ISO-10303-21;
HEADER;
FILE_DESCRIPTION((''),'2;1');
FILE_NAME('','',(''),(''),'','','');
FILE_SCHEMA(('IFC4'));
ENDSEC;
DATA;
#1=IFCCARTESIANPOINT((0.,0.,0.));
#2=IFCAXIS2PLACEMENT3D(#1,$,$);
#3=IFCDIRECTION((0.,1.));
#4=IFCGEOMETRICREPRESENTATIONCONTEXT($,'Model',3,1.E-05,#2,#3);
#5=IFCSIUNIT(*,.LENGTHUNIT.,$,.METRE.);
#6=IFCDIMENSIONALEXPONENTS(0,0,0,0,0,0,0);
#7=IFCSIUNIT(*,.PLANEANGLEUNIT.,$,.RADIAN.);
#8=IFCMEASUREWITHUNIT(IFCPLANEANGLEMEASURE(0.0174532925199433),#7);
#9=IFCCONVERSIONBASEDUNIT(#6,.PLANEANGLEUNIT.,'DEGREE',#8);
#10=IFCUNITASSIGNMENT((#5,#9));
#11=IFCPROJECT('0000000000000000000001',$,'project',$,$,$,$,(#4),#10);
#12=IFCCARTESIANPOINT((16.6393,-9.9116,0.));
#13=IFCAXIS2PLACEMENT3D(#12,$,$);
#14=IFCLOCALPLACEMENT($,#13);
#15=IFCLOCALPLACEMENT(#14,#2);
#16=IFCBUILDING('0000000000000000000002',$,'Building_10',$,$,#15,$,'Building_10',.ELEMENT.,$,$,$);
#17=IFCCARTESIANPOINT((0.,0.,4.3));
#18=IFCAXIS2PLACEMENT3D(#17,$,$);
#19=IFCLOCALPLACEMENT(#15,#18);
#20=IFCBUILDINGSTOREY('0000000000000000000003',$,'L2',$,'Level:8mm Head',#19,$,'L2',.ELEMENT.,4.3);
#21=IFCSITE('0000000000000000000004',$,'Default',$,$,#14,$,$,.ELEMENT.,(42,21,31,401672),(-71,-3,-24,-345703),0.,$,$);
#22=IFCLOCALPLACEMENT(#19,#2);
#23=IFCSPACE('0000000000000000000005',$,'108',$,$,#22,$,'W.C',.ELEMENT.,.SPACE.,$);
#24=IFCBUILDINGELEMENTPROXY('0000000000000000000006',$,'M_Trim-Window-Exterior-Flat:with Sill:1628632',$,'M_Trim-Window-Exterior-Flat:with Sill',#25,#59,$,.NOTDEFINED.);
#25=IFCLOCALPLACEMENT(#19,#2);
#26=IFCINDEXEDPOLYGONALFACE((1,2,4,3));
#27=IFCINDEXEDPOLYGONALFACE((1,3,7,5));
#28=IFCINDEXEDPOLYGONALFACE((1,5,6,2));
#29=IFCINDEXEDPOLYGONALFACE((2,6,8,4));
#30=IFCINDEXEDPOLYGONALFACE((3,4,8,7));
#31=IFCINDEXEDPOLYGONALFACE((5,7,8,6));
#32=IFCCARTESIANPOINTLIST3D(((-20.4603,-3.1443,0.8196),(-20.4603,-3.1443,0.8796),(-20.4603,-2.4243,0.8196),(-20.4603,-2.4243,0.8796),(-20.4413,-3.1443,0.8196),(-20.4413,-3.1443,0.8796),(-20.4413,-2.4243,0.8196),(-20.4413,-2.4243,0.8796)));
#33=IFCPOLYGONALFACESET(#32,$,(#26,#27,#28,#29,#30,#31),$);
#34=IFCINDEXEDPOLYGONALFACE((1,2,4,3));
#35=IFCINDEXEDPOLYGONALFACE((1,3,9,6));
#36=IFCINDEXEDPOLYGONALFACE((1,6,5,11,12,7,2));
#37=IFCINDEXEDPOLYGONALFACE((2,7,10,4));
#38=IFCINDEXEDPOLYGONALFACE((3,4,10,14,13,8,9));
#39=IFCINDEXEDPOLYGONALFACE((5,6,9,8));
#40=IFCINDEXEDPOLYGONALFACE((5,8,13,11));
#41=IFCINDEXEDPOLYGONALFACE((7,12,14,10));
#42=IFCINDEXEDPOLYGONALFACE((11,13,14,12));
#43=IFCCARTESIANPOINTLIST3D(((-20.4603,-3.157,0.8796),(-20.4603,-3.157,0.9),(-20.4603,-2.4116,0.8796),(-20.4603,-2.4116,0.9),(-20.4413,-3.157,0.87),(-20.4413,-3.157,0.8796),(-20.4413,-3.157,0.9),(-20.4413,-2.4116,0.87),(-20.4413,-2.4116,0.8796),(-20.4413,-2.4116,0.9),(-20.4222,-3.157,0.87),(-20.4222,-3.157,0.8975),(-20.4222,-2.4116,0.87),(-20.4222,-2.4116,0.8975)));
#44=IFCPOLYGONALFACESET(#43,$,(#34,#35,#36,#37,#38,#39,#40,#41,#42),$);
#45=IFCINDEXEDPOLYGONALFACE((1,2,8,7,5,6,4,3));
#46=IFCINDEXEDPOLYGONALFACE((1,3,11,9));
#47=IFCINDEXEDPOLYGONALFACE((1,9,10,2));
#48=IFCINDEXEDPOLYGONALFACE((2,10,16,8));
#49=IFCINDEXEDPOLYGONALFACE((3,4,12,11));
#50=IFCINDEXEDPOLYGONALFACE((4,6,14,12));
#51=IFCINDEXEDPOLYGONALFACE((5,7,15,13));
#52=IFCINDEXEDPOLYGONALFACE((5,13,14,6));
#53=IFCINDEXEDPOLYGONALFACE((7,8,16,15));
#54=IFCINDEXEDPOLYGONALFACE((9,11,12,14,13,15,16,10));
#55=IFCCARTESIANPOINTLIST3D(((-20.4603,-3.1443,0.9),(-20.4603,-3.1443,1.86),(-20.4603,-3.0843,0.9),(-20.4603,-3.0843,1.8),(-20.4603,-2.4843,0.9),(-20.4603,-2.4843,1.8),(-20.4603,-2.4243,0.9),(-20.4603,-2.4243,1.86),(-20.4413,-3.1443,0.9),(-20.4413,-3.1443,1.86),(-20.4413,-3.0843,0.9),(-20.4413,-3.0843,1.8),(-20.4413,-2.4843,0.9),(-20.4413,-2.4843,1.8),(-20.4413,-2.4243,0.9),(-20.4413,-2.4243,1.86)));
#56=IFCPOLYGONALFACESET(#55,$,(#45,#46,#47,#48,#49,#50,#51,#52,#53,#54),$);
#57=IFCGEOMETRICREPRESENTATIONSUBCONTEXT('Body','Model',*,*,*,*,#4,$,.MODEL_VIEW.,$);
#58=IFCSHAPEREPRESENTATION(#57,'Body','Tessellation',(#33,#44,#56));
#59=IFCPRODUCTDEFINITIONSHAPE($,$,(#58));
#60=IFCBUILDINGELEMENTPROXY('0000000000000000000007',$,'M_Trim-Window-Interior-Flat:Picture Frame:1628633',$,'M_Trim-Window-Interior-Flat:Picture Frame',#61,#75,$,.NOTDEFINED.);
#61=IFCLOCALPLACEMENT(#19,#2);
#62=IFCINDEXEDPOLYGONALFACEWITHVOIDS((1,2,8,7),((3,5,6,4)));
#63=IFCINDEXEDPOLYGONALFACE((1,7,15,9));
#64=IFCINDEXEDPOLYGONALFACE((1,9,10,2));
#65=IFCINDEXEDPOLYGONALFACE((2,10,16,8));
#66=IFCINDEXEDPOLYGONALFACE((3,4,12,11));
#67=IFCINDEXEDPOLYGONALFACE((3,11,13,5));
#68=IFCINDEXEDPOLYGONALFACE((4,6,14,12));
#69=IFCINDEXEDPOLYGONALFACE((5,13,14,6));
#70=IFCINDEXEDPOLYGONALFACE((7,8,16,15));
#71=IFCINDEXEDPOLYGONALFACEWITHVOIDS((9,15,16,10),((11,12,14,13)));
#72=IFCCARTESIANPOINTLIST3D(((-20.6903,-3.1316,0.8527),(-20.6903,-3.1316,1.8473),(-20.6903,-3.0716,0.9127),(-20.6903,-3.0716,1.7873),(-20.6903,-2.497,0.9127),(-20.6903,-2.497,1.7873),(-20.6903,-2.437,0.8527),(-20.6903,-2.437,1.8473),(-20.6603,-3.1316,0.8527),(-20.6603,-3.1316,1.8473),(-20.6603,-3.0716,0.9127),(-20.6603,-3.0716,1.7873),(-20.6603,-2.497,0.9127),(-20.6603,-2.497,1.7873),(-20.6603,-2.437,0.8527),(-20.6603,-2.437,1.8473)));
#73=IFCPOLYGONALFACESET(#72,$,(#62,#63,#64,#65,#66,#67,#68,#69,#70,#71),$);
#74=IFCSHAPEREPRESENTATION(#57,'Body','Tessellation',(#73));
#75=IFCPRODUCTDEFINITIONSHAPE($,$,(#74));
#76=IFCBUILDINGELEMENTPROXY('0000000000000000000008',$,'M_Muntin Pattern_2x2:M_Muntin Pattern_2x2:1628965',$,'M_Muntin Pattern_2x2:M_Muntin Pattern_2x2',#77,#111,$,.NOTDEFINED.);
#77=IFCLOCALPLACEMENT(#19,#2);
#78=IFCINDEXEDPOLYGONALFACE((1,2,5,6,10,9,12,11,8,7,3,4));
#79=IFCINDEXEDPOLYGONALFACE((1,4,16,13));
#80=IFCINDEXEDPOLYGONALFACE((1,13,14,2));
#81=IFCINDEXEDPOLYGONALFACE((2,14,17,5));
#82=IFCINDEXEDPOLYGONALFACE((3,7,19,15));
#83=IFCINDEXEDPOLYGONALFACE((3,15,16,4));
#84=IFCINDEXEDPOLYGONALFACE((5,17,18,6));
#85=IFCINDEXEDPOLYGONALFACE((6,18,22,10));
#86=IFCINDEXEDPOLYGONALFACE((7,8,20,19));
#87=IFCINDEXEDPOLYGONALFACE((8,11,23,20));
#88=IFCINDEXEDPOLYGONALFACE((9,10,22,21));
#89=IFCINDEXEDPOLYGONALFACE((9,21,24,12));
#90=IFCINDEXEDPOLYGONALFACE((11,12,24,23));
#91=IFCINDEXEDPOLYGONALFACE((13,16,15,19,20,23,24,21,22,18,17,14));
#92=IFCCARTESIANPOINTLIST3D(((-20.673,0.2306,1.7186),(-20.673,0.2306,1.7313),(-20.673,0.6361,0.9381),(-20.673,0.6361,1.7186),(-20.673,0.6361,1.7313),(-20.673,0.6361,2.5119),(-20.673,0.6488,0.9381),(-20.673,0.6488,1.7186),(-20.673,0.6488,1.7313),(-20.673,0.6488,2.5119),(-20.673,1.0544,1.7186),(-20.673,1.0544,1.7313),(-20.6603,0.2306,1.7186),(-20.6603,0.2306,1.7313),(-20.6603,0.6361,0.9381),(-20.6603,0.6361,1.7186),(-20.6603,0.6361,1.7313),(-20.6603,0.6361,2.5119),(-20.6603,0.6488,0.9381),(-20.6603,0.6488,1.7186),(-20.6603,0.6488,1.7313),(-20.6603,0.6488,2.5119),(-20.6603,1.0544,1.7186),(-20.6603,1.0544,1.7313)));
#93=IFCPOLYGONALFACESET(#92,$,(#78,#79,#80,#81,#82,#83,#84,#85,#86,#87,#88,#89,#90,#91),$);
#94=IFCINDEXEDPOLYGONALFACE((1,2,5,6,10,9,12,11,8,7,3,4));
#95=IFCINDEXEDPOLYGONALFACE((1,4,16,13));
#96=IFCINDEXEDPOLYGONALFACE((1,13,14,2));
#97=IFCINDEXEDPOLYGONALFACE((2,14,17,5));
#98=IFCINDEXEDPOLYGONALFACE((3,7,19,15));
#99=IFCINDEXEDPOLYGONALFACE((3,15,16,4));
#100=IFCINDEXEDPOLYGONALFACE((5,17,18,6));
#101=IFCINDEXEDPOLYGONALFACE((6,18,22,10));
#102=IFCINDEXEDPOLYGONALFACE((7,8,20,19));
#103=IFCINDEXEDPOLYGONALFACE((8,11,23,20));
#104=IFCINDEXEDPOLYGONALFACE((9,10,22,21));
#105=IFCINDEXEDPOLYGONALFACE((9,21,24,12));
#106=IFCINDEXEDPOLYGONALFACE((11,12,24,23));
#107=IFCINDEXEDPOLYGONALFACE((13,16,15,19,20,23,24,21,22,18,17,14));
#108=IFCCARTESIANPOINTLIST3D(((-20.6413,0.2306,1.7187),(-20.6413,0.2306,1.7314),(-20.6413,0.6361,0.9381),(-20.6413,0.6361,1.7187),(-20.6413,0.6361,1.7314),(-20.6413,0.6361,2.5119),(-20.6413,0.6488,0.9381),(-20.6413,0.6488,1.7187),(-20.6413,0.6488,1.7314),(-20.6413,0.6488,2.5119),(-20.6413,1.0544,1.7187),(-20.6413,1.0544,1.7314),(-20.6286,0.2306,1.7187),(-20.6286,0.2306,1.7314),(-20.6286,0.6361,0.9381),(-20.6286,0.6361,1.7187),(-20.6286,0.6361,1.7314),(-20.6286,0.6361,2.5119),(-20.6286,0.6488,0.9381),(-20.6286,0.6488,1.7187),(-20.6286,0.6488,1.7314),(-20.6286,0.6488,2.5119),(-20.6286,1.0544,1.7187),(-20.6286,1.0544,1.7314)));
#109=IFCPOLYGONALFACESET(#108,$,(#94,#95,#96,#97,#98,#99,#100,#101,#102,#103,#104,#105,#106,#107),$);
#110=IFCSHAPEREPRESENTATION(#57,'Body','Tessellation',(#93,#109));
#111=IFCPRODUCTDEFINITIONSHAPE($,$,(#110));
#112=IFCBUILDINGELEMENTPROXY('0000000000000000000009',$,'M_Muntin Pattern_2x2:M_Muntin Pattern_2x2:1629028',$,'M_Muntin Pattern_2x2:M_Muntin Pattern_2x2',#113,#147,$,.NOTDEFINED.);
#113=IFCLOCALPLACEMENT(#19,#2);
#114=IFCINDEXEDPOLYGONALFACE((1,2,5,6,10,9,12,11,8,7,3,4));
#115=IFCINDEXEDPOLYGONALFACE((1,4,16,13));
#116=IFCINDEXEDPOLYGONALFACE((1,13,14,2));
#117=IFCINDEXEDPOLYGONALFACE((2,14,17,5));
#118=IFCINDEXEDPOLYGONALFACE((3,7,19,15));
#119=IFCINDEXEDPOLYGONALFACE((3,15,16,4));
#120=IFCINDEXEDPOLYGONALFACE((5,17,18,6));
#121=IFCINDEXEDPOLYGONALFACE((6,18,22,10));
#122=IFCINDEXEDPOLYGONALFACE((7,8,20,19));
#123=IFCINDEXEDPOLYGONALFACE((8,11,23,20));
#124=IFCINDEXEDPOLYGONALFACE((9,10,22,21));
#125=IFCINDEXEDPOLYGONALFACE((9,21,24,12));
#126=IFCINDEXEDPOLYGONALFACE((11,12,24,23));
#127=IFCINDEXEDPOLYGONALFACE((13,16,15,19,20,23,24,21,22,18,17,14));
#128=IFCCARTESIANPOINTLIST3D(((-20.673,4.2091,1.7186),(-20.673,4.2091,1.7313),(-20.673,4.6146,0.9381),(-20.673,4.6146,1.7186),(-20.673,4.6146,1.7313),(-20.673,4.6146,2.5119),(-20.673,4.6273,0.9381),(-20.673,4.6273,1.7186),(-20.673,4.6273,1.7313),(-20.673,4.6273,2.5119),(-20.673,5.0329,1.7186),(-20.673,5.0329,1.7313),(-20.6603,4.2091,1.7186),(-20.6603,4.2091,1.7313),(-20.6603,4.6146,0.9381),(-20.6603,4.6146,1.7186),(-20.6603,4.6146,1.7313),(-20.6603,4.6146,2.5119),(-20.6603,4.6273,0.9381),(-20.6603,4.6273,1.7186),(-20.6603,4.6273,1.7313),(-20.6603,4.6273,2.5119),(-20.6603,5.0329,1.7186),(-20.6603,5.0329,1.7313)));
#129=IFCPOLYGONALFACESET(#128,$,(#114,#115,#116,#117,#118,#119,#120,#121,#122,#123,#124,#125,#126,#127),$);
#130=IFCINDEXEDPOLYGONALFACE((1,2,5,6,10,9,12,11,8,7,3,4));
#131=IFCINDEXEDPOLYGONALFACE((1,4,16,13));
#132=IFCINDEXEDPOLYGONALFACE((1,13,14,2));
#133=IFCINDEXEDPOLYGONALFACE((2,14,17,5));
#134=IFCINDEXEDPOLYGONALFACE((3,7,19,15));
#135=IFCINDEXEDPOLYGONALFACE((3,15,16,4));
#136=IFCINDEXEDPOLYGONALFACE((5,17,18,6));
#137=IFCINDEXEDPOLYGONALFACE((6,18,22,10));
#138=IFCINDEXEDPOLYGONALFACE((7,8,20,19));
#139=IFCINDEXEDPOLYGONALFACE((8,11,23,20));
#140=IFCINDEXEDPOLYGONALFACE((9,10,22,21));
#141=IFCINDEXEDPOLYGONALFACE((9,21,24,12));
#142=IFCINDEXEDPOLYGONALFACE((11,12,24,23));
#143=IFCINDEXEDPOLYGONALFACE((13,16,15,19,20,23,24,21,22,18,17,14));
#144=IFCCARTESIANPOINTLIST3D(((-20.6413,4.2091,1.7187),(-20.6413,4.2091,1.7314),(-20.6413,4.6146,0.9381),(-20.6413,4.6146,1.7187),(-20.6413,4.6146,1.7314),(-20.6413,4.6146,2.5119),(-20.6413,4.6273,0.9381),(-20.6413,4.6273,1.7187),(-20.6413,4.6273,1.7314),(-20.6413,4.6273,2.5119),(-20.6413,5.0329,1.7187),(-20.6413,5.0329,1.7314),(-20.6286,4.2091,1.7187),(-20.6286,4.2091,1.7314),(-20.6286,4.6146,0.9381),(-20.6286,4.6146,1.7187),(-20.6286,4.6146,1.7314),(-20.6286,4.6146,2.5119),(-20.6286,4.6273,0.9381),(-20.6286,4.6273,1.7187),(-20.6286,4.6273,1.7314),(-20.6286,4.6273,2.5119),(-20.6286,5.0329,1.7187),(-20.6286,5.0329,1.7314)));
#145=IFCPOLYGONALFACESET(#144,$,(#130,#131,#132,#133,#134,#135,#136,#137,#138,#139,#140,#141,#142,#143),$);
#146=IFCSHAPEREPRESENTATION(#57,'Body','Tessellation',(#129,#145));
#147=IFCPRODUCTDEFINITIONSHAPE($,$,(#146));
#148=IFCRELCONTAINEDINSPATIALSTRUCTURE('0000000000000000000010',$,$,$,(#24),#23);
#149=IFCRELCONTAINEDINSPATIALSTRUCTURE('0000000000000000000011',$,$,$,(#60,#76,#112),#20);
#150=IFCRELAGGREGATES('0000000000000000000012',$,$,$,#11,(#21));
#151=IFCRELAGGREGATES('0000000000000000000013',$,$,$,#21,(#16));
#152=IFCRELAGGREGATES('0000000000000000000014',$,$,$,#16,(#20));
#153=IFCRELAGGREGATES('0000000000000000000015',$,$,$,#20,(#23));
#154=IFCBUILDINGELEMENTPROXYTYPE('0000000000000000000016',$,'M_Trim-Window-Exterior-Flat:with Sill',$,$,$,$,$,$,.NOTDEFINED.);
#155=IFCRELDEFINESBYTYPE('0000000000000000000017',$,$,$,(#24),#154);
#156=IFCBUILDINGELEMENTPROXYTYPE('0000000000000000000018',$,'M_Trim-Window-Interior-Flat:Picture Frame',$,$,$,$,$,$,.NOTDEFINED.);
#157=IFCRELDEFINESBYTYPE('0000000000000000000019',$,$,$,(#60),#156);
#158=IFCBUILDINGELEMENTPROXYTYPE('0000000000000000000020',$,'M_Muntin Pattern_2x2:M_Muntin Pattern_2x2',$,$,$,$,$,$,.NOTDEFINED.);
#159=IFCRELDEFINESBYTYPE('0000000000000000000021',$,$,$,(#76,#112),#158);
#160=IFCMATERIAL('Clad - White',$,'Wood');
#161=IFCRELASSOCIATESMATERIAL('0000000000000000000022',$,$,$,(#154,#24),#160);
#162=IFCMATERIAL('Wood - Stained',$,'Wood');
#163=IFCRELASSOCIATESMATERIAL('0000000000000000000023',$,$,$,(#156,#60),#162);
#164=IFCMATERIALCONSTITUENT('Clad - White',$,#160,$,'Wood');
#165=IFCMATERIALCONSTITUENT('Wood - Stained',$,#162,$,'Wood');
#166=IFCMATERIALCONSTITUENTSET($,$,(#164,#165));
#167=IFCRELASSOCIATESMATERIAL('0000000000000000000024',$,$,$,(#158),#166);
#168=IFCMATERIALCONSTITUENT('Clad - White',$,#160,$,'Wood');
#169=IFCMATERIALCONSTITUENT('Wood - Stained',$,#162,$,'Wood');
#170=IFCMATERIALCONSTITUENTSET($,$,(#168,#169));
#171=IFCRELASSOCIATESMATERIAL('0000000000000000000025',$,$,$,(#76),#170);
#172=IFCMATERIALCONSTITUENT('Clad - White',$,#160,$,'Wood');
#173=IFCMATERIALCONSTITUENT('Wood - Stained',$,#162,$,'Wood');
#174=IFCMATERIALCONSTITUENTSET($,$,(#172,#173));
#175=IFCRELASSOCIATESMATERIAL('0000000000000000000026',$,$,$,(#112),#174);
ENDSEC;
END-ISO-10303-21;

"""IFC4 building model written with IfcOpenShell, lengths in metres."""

from ifc_helpers import new_model, entity, si_unit, converted_unit, direction, frame, origin, place, context, subcontext, project, spatial, indexed_curve, outline, extrude, source, transform, mapped, material, constituent, constituent_set, type_object, type_shapes, element, save


model = new_model("IFC4")

# Units and contexts
model_context = context("Model", 3, precision=1e-05, world=origin(), true_north=direction((0.0, 1.0)))
body_context = subcontext(model_context, "Body", "Model", "MODEL_VIEW")
ifc_project = project(units=[si_unit("LENGTHUNIT", "METRE"), converted_unit("PLANEANGLEUNIT", "DEGREE", entity("IfcPlaneAngleMeasure", 0.0174532925199433), si_unit("PLANEANGLEUNIT", "RADIAN"), dimensions=[0, 0, 0, 0, 0, 0, 0])], contexts=[model_context])

# Site, building, storey
site_placement = place(None, frame((16.6393, -9.9116, 0.0)))
site = spatial("IfcSite", under=ifc_project, at=site_placement, Name="Default", CompositionType="ELEMENT", RefLatitude=(42, 21, 31, 401672), RefLongitude=(-71, -3, -24, -345703), RefElevation=0.0)
building_placement = place(site_placement, origin())
building = spatial("IfcBuilding", under=site, at=building_placement, Name="Building_10", LongName="Building_10", CompositionType="ELEMENT")
storey_placement = place(building_placement, frame((0.0, 0.0, 4.3)))
storey = spatial("IfcBuildingStorey", under=building, at=storey_placement, Name="L2", ObjectType="Level:8mm Head", LongName="L2", CompositionType="ELEMENT", Elevation=4.3)

# Shared definitions
ifc_material_1 = material(Name="Clad - White", Category="Wood")
ifc_material_2 = material(Name="Wood - Stained", Category="Wood")

# Shared definitions
space_1_placement = place(storey_placement, origin())
space_1 = spatial("IfcSpace", under=storey, at=space_1_placement, Name="108", LongName="W.C", CompositionType="ELEMENT", PredefinedType="SPACE")

# Building element proxies
building_element_proxy_type_1 = type_object("IfcBuildingElementProxyType", Name="M_Trim-Window-Exterior-Flat:with Sill", PredefinedType="NOTDEFINED", material=ifc_material_1)
shared_shape_1 = source(origin(), body_context, "Body", "SweptSolid", [
    extrude(outline(indexed_curve([(-0.36, -0.03), (0.36, -0.03), (0.36, 0.03), (-0.36, 0.03), (-0.36, -0.03)], self_intersect=False)), frame((0.0, -0.9504, 0.0), z_axis=(0.0, 0.0, 1.0), x_axis=(-1.0, 0.0, 0.0)), (0.0, 0.0, 1.0), 0.0191),
    extrude(outline(indexed_curve([(-0.019, -0.0152), (0.0, -0.0152), (0.0, -0.0057), (0.019, -0.0057), (0.019, 0.0148), (0.0, 0.0148), (-0.019, 0.0123), (-0.019, -0.0152)], self_intersect=False)), frame((-0.3727, -0.9148, 0.019), z_axis=(1.0, 0.0, 0.0), x_axis=(0.0, 0.0, -1.0)), (0.0, 0.0, 1.0), 0.7454),
    extrude(outline(indexed_curve([(-0.495, -0.36), (0.465, -0.36), (0.465, -0.3), (-0.435, -0.3), (-0.435, 0.3), (0.465, 0.3), (0.465, 0.36), (-0.495, 0.36), (-0.495, -0.36)], self_intersect=False)), frame((0.0, -0.435, 0.0), z_axis=(0.0, 0.0, 1.0), x_axis=(0.0, -1.0, 0.0)), (0.0, 0.0, 1.0), 0.0191),
])
type_shapes(building_element_proxy_type_1, [shared_shape_1])
proxy_1_placement = place(space_1_placement, frame((-20.4603, -2.7843, 1.8), z_axis=(1.0, 0.0, 0.0), x_axis=(0.0, 1.0, 0.0)))
element("IfcBuildingElementProxy", 1, at=proxy_1_placement, inside=space_1, type_object=building_element_proxy_type_1, material=ifc_material_1, Name="M_Trim-Window-Exterior-Flat:with Sill:1628632", ObjectType="M_Trim-Window-Exterior-Flat:with Sill", PredefinedType="NOTDEFINED", context=body_context, shape_type="MappedRepresentation", body=[
    mapped(shared_shape_1, transform((0.0, 0.0, 0.0), scale=1.0)),
])
building_element_proxy_type_2 = type_object("IfcBuildingElementProxyType", Name="M_Trim-Window-Interior-Flat:Picture Frame", PredefinedType="NOTDEFINED", material=ifc_material_2)
shared_shape_2 = source(origin(), body_context, "Body", "SweptSolid", [
    extrude(outline(indexed_curve([(-0.3473, -0.4973), (0.3473, -0.4973), (0.3473, 0.4973), (-0.3473, 0.4973), (-0.3473, -0.4973)], self_intersect=False), holes=[indexed_curve([(-0.2873, -0.4373), (-0.2873, 0.4373), (0.2873, 0.4373), (0.2873, -0.4373), (-0.2873, -0.4373)], self_intersect=False)]), frame((0.0, -0.45, 0.0), z_axis=(0.0, 0.0, 1.0), x_axis=(-1.0, 0.0, 0.0)), (0.0, 0.0, 1.0), 0.03),
])
type_shapes(building_element_proxy_type_2, [shared_shape_2])
proxy_2_placement = place(storey_placement, frame((-20.6603, -2.7843, 1.8), z_axis=(-1.0, 0.0, 0.0), x_axis=(0.0, -1.0, 0.0)))
element("IfcBuildingElementProxy", 2, at=proxy_2_placement, inside=storey, type_object=building_element_proxy_type_2, material=ifc_material_2, Name="M_Trim-Window-Interior-Flat:Picture Frame:1628633", ObjectType="M_Trim-Window-Interior-Flat:Picture Frame", PredefinedType="NOTDEFINED", context=body_context, shape_type="MappedRepresentation", body=[
    mapped(shared_shape_2, transform((0.0, 0.0, 0.0), scale=1.0)),
])
ifc_constituent_1 = constituent(ifc_material_1, Name="Clad - White", Category="Wood")
ifc_constituent_2 = constituent(ifc_material_2, Name="Wood - Stained", Category="Wood")
ifc_constituent_set_1 = constituent_set(constituents=[ifc_constituent_1, ifc_constituent_2])
ifc_constituent_3 = constituent(ifc_material_1, Name="Clad - White", Category="Wood")
ifc_constituent_4 = constituent(ifc_material_2, Name="Wood - Stained", Category="Wood")
ifc_constituent_set_2 = constituent_set(constituents=[ifc_constituent_3, ifc_constituent_4])
building_element_proxy_type_3 = type_object("IfcBuildingElementProxyType", Name="M_Muntin Pattern_2x2:M_Muntin Pattern_2x2", PredefinedType="NOTDEFINED", material=ifc_constituent_set_2)
shared_shape_3 = source(origin(), body_context, "Body", "SweptSolid", [
    extrude(outline(indexed_curve([(0.0064, -0.0064), (0.7869, -0.0064), (0.7869, 0.0063), (0.0064, 0.0063), (0.0064, 0.4119), (-0.0063, 0.4119), (-0.0063, 0.0063), (-0.7869, 0.0063), (-0.7869, -0.0064), (-0.0063, -0.0064), (-0.0063, -0.4119), (0.0064, -0.4119), (0.0064, -0.0064)], self_intersect=False)), frame((0.0, -0.0222, 0.7869), z_axis=(0.0, 1.0, 0.0), x_axis=(0.0, 0.0, 1.0)), (0.0, 0.0, 1.0), 0.0127),
    extrude(outline(indexed_curve([(0.0064, -0.0064), (0.7869, -0.0064), (0.7869, 0.0063), (0.0064, 0.0063), (0.0064, 0.4119), (-0.0063, 0.4119), (-0.0063, 0.0063), (-0.7869, 0.0063), (-0.7869, -0.0064), (-0.0063, -0.0064), (-0.0063, -0.4119), (0.0064, -0.4119), (0.0064, -0.0064)], self_intersect=False)), frame((0.0, 0.0095, 0.7869), z_axis=(0.0, 1.0, 0.0), x_axis=(0.0, 0.0, 1.0)), (0.0, 0.0, 1.0), 0.0127),
])
type_shapes(building_element_proxy_type_3, [shared_shape_3])
proxy_3_placement = place(storey_placement, frame((-20.6508, 0.6425, 0.9381), z_axis=(0.0, 0.0, 1.0), x_axis=(0.0, -1.0, 0.0)))
element("IfcBuildingElementProxy", 3, at=proxy_3_placement, inside=storey, type_object=building_element_proxy_type_3, material=ifc_constituent_set_1, Name="M_Muntin Pattern_2x2:M_Muntin Pattern_2x2:1628965", ObjectType="M_Muntin Pattern_2x2:M_Muntin Pattern_2x2", PredefinedType="NOTDEFINED", context=body_context, shape_type="MappedRepresentation", body=[
    mapped(shared_shape_3, transform((0.0, 0.0, 0.0), scale=1.0)),
])
ifc_constituent_5 = constituent(ifc_material_1, Name="Clad - White", Category="Wood")
ifc_constituent_6 = constituent(ifc_material_2, Name="Wood - Stained", Category="Wood")
ifc_constituent_set_3 = constituent_set(constituents=[ifc_constituent_5, ifc_constituent_6])
proxy_4_placement = place(storey_placement, frame((-20.6508, 4.621, 0.9381), z_axis=(0.0, 0.0, 1.0), x_axis=(0.0, -1.0, 0.0)))
element("IfcBuildingElementProxy", 4, at=proxy_4_placement, inside=storey, type_object=building_element_proxy_type_3, material=ifc_constituent_set_3, Name="M_Muntin Pattern_2x2:M_Muntin Pattern_2x2:1629028", ObjectType="M_Muntin Pattern_2x2:M_Muntin Pattern_2x2", PredefinedType="NOTDEFINED", context=body_context, shape_type="MappedRepresentation", body=[
    mapped(shared_shape_3, transform((0.0, 0.0, 0.0), scale=1.0)),
])

save(model, "model.ifc")
